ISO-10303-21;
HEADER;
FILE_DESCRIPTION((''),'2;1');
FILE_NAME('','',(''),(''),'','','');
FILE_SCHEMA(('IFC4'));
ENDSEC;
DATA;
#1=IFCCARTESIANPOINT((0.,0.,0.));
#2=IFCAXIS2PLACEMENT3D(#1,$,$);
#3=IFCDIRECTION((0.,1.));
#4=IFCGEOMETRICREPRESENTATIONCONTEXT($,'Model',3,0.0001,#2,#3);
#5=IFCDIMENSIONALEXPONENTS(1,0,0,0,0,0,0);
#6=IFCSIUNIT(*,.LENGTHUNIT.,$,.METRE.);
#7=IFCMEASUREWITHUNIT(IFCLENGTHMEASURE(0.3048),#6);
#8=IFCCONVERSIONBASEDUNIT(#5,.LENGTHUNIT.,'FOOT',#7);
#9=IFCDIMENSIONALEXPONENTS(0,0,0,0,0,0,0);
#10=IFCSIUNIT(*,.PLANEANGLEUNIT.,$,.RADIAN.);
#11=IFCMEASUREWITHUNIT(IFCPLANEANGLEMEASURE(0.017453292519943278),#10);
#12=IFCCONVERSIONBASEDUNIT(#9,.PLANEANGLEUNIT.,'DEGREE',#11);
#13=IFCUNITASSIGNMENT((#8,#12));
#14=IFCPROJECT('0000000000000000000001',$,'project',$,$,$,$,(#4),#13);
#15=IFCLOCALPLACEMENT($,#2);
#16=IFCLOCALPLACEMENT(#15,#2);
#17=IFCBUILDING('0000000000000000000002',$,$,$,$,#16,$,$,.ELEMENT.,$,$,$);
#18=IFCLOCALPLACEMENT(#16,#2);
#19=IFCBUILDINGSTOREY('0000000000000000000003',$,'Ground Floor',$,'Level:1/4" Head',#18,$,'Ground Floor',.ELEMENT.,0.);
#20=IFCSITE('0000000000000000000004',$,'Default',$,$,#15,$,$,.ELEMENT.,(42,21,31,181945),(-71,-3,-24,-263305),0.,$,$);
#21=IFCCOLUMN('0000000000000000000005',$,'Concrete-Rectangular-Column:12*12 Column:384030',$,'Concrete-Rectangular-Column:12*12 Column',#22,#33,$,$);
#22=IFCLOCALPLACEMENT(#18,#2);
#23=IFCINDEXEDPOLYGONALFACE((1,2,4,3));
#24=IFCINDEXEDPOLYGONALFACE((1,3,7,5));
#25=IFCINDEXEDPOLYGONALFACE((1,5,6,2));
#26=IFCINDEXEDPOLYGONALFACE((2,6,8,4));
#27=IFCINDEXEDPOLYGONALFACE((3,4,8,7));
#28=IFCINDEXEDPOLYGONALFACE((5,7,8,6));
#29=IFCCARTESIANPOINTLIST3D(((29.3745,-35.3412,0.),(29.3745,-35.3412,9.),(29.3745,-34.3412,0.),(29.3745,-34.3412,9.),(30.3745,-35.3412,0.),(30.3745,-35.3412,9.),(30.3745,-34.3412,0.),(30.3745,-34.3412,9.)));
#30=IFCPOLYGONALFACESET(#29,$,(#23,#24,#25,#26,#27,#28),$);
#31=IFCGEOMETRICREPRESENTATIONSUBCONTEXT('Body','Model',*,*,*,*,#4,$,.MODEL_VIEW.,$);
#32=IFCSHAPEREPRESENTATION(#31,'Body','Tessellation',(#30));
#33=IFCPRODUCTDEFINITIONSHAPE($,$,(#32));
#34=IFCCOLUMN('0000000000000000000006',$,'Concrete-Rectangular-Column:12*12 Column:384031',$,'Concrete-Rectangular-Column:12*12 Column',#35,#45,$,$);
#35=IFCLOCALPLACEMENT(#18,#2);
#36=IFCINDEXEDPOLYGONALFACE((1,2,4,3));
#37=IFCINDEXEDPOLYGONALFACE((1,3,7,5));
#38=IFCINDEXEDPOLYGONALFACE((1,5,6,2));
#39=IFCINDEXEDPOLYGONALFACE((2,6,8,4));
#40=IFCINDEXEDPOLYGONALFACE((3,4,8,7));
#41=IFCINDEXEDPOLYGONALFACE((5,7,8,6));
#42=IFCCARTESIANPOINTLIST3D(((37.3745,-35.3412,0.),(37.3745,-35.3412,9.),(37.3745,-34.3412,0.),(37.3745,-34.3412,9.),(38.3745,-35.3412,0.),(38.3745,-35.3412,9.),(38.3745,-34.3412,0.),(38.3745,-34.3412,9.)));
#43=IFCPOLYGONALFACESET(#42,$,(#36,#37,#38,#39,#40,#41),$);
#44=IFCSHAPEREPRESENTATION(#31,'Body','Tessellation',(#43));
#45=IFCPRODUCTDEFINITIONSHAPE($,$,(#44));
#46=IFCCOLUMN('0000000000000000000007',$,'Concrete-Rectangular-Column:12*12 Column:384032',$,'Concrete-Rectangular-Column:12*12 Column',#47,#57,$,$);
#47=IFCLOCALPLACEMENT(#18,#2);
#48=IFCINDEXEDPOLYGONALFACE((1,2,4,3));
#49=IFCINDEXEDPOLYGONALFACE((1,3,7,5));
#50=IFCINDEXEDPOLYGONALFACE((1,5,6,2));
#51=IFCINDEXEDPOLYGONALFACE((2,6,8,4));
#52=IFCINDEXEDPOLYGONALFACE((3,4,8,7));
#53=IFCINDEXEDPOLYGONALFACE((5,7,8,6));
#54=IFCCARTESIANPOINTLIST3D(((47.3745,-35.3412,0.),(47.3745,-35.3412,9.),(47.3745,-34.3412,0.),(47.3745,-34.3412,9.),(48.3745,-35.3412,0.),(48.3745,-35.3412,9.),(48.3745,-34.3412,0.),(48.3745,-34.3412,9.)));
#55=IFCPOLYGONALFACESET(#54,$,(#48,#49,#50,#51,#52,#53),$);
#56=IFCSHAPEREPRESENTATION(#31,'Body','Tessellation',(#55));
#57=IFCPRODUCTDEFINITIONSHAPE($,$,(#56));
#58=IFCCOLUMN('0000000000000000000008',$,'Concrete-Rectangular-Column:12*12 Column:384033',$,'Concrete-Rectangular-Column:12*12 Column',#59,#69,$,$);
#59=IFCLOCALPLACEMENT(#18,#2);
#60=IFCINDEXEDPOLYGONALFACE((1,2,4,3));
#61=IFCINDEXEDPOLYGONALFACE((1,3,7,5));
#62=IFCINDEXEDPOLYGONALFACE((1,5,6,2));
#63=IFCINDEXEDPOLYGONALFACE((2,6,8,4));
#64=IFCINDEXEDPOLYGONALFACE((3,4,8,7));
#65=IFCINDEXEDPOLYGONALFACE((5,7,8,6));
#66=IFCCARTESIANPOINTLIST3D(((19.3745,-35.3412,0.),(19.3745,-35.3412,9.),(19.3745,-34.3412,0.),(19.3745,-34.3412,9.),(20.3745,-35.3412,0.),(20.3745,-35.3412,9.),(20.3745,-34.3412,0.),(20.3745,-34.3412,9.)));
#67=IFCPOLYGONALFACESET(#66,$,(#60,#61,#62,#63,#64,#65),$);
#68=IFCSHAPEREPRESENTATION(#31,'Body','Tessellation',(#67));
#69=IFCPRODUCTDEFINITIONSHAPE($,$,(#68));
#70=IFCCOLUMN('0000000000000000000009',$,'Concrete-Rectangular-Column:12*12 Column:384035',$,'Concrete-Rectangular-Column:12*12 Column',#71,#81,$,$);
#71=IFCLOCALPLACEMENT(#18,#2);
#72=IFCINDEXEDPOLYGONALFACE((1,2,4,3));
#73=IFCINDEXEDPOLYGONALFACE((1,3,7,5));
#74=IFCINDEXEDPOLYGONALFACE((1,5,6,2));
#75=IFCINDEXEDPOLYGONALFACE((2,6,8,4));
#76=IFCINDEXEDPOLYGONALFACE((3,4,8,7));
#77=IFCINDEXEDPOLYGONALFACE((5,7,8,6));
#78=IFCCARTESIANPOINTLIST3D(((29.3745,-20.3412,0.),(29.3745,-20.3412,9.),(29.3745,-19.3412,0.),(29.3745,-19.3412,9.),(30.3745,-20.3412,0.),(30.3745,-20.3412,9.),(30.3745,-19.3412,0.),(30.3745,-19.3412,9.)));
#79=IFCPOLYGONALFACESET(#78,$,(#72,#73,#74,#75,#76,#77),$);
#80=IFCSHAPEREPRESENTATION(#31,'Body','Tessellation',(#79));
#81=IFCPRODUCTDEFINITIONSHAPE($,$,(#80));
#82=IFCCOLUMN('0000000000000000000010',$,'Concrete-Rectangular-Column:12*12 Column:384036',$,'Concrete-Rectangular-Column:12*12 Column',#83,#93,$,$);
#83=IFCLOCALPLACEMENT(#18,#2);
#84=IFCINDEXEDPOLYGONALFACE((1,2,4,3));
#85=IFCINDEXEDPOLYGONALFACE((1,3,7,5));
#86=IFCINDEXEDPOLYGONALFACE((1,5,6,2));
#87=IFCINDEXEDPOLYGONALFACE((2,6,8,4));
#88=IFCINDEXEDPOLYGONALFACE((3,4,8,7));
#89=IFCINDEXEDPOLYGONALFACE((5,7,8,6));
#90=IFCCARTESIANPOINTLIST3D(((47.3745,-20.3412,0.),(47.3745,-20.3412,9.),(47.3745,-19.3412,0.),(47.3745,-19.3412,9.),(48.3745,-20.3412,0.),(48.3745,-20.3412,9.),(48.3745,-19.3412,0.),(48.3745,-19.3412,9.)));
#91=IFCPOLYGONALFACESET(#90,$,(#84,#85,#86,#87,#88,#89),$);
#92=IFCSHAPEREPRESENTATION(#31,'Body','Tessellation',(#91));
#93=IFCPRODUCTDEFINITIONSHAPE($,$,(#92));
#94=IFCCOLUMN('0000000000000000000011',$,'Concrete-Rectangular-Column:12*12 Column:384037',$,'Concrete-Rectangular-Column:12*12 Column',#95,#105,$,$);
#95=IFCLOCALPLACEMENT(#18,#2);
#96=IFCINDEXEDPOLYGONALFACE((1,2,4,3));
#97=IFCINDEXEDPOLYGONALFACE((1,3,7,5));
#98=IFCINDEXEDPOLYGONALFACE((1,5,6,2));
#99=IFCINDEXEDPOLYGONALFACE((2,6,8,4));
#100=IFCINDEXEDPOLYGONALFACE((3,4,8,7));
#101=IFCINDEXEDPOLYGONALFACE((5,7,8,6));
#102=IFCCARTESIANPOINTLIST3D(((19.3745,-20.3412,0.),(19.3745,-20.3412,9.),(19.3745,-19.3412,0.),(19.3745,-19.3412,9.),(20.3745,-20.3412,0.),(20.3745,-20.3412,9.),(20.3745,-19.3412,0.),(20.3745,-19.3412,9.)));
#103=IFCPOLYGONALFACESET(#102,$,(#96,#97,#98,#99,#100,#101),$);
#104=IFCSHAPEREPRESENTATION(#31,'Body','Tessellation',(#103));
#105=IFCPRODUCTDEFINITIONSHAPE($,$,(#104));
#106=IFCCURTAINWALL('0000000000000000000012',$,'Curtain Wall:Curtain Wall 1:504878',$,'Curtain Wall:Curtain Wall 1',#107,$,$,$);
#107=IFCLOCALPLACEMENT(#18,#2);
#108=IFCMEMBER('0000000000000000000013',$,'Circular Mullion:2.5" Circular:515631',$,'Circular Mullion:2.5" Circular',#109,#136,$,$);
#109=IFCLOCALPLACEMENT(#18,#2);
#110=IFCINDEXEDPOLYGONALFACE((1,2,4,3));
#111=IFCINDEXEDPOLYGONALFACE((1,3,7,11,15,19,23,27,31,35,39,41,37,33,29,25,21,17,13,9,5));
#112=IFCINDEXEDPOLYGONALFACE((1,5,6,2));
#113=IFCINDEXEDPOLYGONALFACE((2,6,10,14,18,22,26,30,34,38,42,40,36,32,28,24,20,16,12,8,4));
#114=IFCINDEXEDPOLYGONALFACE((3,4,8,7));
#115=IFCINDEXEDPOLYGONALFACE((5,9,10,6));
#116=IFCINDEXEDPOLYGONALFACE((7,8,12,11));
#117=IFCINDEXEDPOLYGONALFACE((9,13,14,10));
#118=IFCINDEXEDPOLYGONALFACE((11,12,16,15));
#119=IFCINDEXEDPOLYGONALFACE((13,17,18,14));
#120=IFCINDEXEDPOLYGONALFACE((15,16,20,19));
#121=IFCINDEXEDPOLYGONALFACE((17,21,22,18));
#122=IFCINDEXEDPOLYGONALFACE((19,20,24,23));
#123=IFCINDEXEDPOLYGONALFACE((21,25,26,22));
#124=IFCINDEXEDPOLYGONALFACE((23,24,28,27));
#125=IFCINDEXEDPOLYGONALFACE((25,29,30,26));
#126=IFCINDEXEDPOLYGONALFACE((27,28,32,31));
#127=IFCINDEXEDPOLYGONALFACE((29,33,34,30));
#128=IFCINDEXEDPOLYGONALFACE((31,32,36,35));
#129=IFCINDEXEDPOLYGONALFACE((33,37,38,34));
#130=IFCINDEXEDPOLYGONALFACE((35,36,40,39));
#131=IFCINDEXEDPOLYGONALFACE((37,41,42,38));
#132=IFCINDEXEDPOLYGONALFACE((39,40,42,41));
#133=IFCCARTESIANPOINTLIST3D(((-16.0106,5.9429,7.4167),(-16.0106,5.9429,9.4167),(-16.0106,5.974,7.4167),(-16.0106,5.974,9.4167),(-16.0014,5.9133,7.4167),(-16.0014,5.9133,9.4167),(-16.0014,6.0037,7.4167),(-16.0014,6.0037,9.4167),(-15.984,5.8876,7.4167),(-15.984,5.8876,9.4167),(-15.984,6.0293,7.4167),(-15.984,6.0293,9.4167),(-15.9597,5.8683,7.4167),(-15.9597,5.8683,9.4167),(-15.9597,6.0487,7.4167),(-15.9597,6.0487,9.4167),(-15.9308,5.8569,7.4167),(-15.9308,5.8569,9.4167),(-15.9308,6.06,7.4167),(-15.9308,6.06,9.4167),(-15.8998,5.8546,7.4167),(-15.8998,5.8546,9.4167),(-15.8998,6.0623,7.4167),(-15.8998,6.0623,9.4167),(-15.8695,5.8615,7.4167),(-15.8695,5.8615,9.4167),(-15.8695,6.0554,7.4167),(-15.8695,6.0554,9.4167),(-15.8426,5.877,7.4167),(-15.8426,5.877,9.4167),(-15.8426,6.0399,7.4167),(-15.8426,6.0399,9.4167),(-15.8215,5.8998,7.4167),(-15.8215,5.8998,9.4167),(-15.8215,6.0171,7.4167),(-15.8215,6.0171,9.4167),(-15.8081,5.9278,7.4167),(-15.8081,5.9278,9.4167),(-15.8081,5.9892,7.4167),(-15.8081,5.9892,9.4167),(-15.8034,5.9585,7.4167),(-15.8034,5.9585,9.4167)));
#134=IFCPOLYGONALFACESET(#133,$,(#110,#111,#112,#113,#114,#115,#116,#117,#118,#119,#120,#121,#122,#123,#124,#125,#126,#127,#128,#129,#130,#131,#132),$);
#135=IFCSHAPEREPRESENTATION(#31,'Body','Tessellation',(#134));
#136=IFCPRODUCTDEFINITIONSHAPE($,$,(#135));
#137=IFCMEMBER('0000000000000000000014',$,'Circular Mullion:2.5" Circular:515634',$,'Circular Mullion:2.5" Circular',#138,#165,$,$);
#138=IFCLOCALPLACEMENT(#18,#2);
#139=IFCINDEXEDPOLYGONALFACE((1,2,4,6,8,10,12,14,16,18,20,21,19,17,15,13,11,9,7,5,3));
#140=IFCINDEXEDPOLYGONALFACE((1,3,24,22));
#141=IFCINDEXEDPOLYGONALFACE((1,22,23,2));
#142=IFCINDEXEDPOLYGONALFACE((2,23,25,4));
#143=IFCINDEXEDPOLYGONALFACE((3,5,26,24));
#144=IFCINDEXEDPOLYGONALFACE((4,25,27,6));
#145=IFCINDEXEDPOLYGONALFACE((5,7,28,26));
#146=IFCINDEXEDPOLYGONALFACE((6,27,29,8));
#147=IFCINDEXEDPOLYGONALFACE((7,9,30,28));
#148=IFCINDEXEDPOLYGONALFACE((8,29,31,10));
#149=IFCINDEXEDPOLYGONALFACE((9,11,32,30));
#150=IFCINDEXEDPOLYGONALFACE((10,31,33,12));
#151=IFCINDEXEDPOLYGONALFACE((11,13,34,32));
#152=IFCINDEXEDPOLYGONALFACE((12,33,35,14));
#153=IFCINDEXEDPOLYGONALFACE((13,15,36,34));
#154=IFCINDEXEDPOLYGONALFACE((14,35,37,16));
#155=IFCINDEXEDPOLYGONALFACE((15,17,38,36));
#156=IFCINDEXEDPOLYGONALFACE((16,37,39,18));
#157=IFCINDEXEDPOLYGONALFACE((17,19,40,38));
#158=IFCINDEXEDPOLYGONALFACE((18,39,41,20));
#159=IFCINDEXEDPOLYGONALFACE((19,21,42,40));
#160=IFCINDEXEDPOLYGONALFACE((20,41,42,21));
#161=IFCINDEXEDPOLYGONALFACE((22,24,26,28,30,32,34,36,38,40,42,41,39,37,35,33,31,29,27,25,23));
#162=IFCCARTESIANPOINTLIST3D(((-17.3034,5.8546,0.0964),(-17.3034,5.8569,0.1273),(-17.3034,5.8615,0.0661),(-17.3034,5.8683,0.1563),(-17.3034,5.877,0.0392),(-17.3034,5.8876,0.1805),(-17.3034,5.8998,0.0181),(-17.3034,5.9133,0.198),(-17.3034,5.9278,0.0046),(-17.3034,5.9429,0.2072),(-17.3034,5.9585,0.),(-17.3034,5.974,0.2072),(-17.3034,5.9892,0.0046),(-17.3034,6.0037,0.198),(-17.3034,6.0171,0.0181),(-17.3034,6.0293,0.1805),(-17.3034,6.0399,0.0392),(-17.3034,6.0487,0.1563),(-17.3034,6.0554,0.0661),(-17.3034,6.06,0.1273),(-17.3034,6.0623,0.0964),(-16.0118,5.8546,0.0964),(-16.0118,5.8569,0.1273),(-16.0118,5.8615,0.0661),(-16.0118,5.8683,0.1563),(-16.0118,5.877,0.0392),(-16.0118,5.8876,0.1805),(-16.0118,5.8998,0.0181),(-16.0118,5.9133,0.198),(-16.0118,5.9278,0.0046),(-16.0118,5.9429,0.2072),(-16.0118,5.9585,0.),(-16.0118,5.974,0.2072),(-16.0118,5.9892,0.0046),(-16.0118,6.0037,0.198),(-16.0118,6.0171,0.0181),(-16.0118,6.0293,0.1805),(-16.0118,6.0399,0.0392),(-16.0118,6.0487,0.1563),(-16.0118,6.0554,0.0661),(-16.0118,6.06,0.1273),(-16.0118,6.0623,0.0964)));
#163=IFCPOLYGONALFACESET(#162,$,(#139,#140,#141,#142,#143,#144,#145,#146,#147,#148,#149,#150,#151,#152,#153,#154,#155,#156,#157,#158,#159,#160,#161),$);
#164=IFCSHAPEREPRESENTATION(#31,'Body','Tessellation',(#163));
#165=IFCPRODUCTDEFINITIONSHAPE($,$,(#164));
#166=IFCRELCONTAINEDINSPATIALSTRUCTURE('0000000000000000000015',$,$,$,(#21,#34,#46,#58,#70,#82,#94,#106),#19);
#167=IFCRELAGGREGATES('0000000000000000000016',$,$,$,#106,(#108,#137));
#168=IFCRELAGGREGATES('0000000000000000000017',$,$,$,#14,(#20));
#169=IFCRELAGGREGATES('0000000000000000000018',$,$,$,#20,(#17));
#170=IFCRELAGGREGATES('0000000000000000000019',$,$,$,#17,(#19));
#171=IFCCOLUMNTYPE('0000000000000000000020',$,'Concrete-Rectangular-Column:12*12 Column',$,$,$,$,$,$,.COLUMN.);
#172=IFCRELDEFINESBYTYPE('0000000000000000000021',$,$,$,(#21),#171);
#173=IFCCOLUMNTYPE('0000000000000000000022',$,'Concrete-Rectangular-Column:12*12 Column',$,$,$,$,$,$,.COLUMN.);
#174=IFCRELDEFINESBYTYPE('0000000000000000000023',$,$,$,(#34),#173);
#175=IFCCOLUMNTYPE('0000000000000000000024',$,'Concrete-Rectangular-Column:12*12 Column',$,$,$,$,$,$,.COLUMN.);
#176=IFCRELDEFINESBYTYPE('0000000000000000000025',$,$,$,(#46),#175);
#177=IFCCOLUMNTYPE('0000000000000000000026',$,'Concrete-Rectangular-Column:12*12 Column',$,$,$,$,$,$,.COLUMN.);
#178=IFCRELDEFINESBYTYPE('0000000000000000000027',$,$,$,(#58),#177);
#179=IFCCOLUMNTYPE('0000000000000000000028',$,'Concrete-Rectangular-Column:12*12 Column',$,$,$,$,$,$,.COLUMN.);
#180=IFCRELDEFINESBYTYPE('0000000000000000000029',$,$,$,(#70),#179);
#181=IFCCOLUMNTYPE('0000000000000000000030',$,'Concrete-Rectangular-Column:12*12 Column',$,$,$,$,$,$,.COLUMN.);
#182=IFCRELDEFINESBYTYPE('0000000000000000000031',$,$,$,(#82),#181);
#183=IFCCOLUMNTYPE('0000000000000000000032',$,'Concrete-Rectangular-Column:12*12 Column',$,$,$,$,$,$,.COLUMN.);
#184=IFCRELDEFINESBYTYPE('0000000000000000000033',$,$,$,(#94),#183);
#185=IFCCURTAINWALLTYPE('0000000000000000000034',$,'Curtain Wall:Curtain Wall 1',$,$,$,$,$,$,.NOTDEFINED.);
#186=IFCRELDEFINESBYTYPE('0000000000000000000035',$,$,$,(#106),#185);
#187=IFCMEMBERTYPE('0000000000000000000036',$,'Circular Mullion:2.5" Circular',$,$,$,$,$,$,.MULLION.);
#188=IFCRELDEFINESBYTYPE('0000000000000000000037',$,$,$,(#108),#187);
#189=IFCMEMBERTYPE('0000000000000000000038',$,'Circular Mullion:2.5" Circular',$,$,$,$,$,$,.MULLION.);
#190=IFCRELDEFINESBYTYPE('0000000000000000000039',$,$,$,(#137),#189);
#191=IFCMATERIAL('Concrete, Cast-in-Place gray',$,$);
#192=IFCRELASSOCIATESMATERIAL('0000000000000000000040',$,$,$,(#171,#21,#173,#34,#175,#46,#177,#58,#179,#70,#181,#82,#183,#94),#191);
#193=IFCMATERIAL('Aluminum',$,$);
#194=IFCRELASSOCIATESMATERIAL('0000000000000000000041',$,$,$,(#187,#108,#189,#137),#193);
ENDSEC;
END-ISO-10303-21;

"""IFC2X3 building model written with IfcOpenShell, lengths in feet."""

from ifc_helpers import new_model, entity, si_unit, converted_unit, direction, frame, frame_2d, origin, origin_2d_with_axis, place, context, subcontext, project, spatial, rectangle, circle, extrude, source, transform, mapped, material, type_object, type_shapes, element, aggregate, save


model = new_model("IFC2X3")

# Units and contexts
model_context = context("Model", 3, precision=0.0001, world=origin(), true_north=direction((0.0, 1.0)))
body_context = subcontext(model_context, "Body", "Model", "MODEL_VIEW")
ifc_project = project(units=[converted_unit("LENGTHUNIT", "FOOT", entity("IfcLengthMeasure", 0.3048), si_unit("LENGTHUNIT", "METRE"), dimensions=[1, 0, 0, 0, 0, 0, 0]), converted_unit("PLANEANGLEUNIT", "DEGREE", entity("IfcPlaneAngleMeasure", 0.017453292519943278), si_unit("PLANEANGLEUNIT", "RADIAN"), dimensions=[0, 0, 0, 0, 0, 0, 0])], contexts=[model_context])

# Site, building, storey
site_placement = place(None, origin())
site = spatial("IfcSite", under=ifc_project, at=site_placement, Name="Default", CompositionType="ELEMENT", RefLatitude=(42, 21, 31, 181945), RefLongitude=(-71, -3, -24, -263305), RefElevation=0.0)
building_placement = place(site_placement, origin())
building = spatial("IfcBuilding", under=site, at=building_placement, CompositionType="ELEMENT")
storey_placement = place(building_placement, origin())
storey = spatial("IfcBuildingStorey", under=building, at=storey_placement, Name="Ground Floor", ObjectType="Level:1/4\" Head", LongName="Ground Floor", CompositionType="ELEMENT", Elevation=0.0)

# Columns
ifc_material_1 = material(Name="Concrete, Cast-in-Place gray")
column_type_1 = type_object("IfcColumnType", Name="Concrete-Rectangular-Column:12*12 Column", PredefinedType="COLUMN", material=ifc_material_1)
shared_shape_1 = source(origin(), body_context, "Body", "SweptSolid", [
    extrude(rectangle(XDim=1.0, YDim=1.0, at=frame_2d((0.0, 0.0), x_axis=(1.0, 0.0))), frame((29.8745, -34.8412, 0.0), z_axis=(0.0, 0.0, 1.0), x_axis=(-1.0, 0.0, 0.0)), (0.0, 0.0, 1.0), 9.0),
])
type_shapes(column_type_1, [shared_shape_1])
column_1_placement = place(storey_placement, origin())
element("IfcColumn", 1, at=column_1_placement, inside=storey, type_object=column_type_1, material=ifc_material_1, Name="Concrete-Rectangular-Column:12*12 Column:384030", ObjectType="Concrete-Rectangular-Column:12*12 Column", context=body_context, shape_type="MappedRepresentation", body=[
    mapped(shared_shape_1, transform((0.0, 0.0, 0.0), scale=1.0)),
])
column_type_2 = type_object("IfcColumnType", Name="Concrete-Rectangular-Column:12*12 Column", PredefinedType="COLUMN", material=ifc_material_1)
shared_shape_2 = source(origin(), body_context, "Body", "SweptSolid", [
    extrude(rectangle(XDim=1.0, YDim=1.0, at=origin_2d_with_axis()), frame((37.8745, -34.8412, 0.0), z_axis=(0.0, 0.0, 1.0), x_axis=(-1.0, 0.0, 0.0)), (0.0, 0.0, 1.0), 9.0),
])
type_shapes(column_type_2, [shared_shape_2])
column_2_placement = place(storey_placement, origin())
element("IfcColumn", 2, at=column_2_placement, inside=storey, type_object=column_type_2, material=ifc_material_1, Name="Concrete-Rectangular-Column:12*12 Column:384031", ObjectType="Concrete-Rectangular-Column:12*12 Column", context=body_context, shape_type="MappedRepresentation", body=[
    mapped(shared_shape_2, transform((0.0, 0.0, 0.0), scale=1.0)),
])
column_type_3 = type_object("IfcColumnType", Name="Concrete-Rectangular-Column:12*12 Column", PredefinedType="COLUMN", material=ifc_material_1)
shared_shape_3 = source(origin(), body_context, "Body", "SweptSolid", [
    extrude(rectangle(XDim=1.0, YDim=1.0, at=origin_2d_with_axis()), frame((47.8745, -34.8412, 0.0), z_axis=(0.0, 0.0, 1.0), x_axis=(-1.0, 0.0, 0.0)), (0.0, 0.0, 1.0), 9.0),
])
type_shapes(column_type_3, [shared_shape_3])
column_3_placement = place(storey_placement, origin())
element("IfcColumn", 3, at=column_3_placement, inside=storey, type_object=column_type_3, material=ifc_material_1, Name="Concrete-Rectangular-Column:12*12 Column:384032", ObjectType="Concrete-Rectangular-Column:12*12 Column", context=body_context, shape_type="MappedRepresentation", body=[
    mapped(shared_shape_3, transform((0.0, 0.0, 0.0), scale=1.0)),
])
column_type_4 = type_object("IfcColumnType", Name="Concrete-Rectangular-Column:12*12 Column", PredefinedType="COLUMN", material=ifc_material_1)
shared_shape_4 = source(origin(), body_context, "Body", "SweptSolid", [
    extrude(rectangle(XDim=1.0, YDim=1.0, at=frame_2d((0.0, 0.0), x_axis=(1.0, 0.0))), frame((19.8745, -34.8412, 0.0), z_axis=(0.0, 0.0, 1.0), x_axis=(-1.0, 0.0, 0.0)), (0.0, 0.0, 1.0), 9.0),
])
type_shapes(column_type_4, [shared_shape_4])
column_4_placement = place(storey_placement, origin())
element("IfcColumn", 4, at=column_4_placement, inside=storey, type_object=column_type_4, material=ifc_material_1, Name="Concrete-Rectangular-Column:12*12 Column:384033", ObjectType="Concrete-Rectangular-Column:12*12 Column", context=body_context, shape_type="MappedRepresentation", body=[
    mapped(shared_shape_4, transform((0.0, 0.0, 0.0), scale=1.0)),
])
column_type_5 = type_object("IfcColumnType", Name="Concrete-Rectangular-Column:12*12 Column", PredefinedType="COLUMN", material=ifc_material_1)
shared_shape_5 = source(origin(), body_context, "Body", "SweptSolid", [
    extrude(rectangle(XDim=1.0, YDim=1.0, at=frame_2d((0.0, 0.0), x_axis=(1.0, 0.0))), frame((29.8745, -19.8412, 0.0), z_axis=(0.0, 0.0, 1.0), x_axis=(-1.0, 0.0, 0.0)), (0.0, 0.0, 1.0), 9.0),
])
type_shapes(column_type_5, [shared_shape_5])
column_5_placement = place(storey_placement, origin())
element("IfcColumn", 5, at=column_5_placement, inside=storey, type_object=column_type_5, material=ifc_material_1, Name="Concrete-Rectangular-Column:12*12 Column:384035", ObjectType="Concrete-Rectangular-Column:12*12 Column", context=body_context, shape_type="MappedRepresentation", body=[
    mapped(shared_shape_5, transform((0.0, 0.0, 0.0), scale=1.0)),
])
column_type_6 = type_object("IfcColumnType", Name="Concrete-Rectangular-Column:12*12 Column", PredefinedType="COLUMN", material=ifc_material_1)
shared_shape_6 = source(origin(), body_context, "Body", "SweptSolid", [
    extrude(rectangle(XDim=1.0, YDim=1.0, at=frame_2d((0.0, 0.0), x_axis=(1.0, 0.0))), frame((47.8745, -19.8412, 0.0), z_axis=(0.0, 0.0, 1.0), x_axis=(-1.0, 0.0, 0.0)), (0.0, 0.0, 1.0), 9.0),
])
type_shapes(column_type_6, [shared_shape_6])
column_6_placement = place(storey_placement, origin())
element("IfcColumn", 6, at=column_6_placement, inside=storey, type_object=column_type_6, material=ifc_material_1, Name="Concrete-Rectangular-Column:12*12 Column:384036", ObjectType="Concrete-Rectangular-Column:12*12 Column", context=body_context, shape_type="MappedRepresentation", body=[
    mapped(shared_shape_6, transform((0.0, 0.0, 0.0), scale=1.0)),
])
column_type_7 = type_object("IfcColumnType", Name="Concrete-Rectangular-Column:12*12 Column", PredefinedType="COLUMN", material=ifc_material_1)
shared_shape_7 = source(origin(), body_context, "Body", "SweptSolid", [
    extrude(rectangle(XDim=1.0, YDim=1.0, at=frame_2d((0.0, 0.0), x_axis=(1.0, 0.0))), frame((19.8745, -19.8412, 0.0), z_axis=(0.0, 0.0, 1.0), x_axis=(-1.0, 0.0, 0.0)), (0.0, 0.0, 1.0), 9.0),
])
type_shapes(column_type_7, [shared_shape_7])
column_7_placement = place(storey_placement, origin())
element("IfcColumn", 7, at=column_7_placement, inside=storey, type_object=column_type_7, material=ifc_material_1, Name="Concrete-Rectangular-Column:12*12 Column:384037", ObjectType="Concrete-Rectangular-Column:12*12 Column", context=body_context, shape_type="MappedRepresentation", body=[
    mapped(shared_shape_7, transform((0.0, 0.0, 0.0), scale=1.0)),
])

# Curtain wall, members
curtain_wall_type = type_object("IfcCurtainWallType", Name="Curtain Wall:Curtain Wall 1", PredefinedType="NOTDEFINED")
curtain_wall_placement = place(storey_placement, origin())
curtain_wall = element("IfcCurtainWall", 8, at=curtain_wall_placement, inside=storey, type_object=curtain_wall_type, Name="Curtain Wall:Curtain Wall 1:504878", ObjectType="Curtain Wall:Curtain Wall 1")
ifc_material_2 = material(Name="Aluminum")
member_type_1 = type_object("IfcMemberType", Name="Circular Mullion:2.5\" Circular", PredefinedType="MULLION", material=ifc_material_2)
shared_shape_8 = source(origin(), body_context, "Body", "SweptSolid", [
    extrude(circle(Radius=0.1042, at=frame_2d((0.0, 0.0), x_axis=(1.0, 0.0))), frame((-0.1042, 0.0, -2.0)), (0.0, 0.0, 1.0), 2.0),
])
type_shapes(member_type_1, [shared_shape_8])
member_1_placement = place(curtain_wall_placement, frame((-15.8034, 5.9585, 9.4167)))
member_1 = element("IfcMember", 9, at=member_1_placement, type_object=member_type_1, material=ifc_material_2, Name="Circular Mullion:2.5\" Circular:515631", ObjectType="Circular Mullion:2.5\" Circular", context=body_context, shape_type="MappedRepresentation", body=[
    mapped(shared_shape_8, transform((0.0, 0.0, 0.0), scale=1.0)),
])
member_type_2 = type_object("IfcMemberType", Name="Circular Mullion:2.5\" Circular", PredefinedType="MULLION", material=ifc_material_2)
shared_shape_9 = source(origin(), body_context, "Body", "SweptSolid", [
    extrude(circle(Radius=0.1042, at=frame_2d((0.0, 0.0), x_axis=(1.0, 0.0))), frame((-0.1042, 0.0, -1.2917)), (0.0, 0.0, 1.0), 1.2917),
])
type_shapes(member_type_2, [shared_shape_9])
member_2_placement = place(curtain_wall_placement, frame((-16.0118, 5.9585, 0.0), z_axis=(1.0, 0.0, 0.0), x_axis=(0.0, 0.0, -1.0)))
member_2 = element("IfcMember", 10, at=member_2_placement, type_object=member_type_2, material=ifc_material_2, Name="Circular Mullion:2.5\" Circular:515634", ObjectType="Circular Mullion:2.5\" Circular", context=body_context, shape_type="MappedRepresentation", body=[
    mapped(shared_shape_9, transform((0.0, 0.0, 0.0), scale=1.0)),
])
aggregate(curtain_wall, [member_1, member_2])

save(model, "model.ifc")
